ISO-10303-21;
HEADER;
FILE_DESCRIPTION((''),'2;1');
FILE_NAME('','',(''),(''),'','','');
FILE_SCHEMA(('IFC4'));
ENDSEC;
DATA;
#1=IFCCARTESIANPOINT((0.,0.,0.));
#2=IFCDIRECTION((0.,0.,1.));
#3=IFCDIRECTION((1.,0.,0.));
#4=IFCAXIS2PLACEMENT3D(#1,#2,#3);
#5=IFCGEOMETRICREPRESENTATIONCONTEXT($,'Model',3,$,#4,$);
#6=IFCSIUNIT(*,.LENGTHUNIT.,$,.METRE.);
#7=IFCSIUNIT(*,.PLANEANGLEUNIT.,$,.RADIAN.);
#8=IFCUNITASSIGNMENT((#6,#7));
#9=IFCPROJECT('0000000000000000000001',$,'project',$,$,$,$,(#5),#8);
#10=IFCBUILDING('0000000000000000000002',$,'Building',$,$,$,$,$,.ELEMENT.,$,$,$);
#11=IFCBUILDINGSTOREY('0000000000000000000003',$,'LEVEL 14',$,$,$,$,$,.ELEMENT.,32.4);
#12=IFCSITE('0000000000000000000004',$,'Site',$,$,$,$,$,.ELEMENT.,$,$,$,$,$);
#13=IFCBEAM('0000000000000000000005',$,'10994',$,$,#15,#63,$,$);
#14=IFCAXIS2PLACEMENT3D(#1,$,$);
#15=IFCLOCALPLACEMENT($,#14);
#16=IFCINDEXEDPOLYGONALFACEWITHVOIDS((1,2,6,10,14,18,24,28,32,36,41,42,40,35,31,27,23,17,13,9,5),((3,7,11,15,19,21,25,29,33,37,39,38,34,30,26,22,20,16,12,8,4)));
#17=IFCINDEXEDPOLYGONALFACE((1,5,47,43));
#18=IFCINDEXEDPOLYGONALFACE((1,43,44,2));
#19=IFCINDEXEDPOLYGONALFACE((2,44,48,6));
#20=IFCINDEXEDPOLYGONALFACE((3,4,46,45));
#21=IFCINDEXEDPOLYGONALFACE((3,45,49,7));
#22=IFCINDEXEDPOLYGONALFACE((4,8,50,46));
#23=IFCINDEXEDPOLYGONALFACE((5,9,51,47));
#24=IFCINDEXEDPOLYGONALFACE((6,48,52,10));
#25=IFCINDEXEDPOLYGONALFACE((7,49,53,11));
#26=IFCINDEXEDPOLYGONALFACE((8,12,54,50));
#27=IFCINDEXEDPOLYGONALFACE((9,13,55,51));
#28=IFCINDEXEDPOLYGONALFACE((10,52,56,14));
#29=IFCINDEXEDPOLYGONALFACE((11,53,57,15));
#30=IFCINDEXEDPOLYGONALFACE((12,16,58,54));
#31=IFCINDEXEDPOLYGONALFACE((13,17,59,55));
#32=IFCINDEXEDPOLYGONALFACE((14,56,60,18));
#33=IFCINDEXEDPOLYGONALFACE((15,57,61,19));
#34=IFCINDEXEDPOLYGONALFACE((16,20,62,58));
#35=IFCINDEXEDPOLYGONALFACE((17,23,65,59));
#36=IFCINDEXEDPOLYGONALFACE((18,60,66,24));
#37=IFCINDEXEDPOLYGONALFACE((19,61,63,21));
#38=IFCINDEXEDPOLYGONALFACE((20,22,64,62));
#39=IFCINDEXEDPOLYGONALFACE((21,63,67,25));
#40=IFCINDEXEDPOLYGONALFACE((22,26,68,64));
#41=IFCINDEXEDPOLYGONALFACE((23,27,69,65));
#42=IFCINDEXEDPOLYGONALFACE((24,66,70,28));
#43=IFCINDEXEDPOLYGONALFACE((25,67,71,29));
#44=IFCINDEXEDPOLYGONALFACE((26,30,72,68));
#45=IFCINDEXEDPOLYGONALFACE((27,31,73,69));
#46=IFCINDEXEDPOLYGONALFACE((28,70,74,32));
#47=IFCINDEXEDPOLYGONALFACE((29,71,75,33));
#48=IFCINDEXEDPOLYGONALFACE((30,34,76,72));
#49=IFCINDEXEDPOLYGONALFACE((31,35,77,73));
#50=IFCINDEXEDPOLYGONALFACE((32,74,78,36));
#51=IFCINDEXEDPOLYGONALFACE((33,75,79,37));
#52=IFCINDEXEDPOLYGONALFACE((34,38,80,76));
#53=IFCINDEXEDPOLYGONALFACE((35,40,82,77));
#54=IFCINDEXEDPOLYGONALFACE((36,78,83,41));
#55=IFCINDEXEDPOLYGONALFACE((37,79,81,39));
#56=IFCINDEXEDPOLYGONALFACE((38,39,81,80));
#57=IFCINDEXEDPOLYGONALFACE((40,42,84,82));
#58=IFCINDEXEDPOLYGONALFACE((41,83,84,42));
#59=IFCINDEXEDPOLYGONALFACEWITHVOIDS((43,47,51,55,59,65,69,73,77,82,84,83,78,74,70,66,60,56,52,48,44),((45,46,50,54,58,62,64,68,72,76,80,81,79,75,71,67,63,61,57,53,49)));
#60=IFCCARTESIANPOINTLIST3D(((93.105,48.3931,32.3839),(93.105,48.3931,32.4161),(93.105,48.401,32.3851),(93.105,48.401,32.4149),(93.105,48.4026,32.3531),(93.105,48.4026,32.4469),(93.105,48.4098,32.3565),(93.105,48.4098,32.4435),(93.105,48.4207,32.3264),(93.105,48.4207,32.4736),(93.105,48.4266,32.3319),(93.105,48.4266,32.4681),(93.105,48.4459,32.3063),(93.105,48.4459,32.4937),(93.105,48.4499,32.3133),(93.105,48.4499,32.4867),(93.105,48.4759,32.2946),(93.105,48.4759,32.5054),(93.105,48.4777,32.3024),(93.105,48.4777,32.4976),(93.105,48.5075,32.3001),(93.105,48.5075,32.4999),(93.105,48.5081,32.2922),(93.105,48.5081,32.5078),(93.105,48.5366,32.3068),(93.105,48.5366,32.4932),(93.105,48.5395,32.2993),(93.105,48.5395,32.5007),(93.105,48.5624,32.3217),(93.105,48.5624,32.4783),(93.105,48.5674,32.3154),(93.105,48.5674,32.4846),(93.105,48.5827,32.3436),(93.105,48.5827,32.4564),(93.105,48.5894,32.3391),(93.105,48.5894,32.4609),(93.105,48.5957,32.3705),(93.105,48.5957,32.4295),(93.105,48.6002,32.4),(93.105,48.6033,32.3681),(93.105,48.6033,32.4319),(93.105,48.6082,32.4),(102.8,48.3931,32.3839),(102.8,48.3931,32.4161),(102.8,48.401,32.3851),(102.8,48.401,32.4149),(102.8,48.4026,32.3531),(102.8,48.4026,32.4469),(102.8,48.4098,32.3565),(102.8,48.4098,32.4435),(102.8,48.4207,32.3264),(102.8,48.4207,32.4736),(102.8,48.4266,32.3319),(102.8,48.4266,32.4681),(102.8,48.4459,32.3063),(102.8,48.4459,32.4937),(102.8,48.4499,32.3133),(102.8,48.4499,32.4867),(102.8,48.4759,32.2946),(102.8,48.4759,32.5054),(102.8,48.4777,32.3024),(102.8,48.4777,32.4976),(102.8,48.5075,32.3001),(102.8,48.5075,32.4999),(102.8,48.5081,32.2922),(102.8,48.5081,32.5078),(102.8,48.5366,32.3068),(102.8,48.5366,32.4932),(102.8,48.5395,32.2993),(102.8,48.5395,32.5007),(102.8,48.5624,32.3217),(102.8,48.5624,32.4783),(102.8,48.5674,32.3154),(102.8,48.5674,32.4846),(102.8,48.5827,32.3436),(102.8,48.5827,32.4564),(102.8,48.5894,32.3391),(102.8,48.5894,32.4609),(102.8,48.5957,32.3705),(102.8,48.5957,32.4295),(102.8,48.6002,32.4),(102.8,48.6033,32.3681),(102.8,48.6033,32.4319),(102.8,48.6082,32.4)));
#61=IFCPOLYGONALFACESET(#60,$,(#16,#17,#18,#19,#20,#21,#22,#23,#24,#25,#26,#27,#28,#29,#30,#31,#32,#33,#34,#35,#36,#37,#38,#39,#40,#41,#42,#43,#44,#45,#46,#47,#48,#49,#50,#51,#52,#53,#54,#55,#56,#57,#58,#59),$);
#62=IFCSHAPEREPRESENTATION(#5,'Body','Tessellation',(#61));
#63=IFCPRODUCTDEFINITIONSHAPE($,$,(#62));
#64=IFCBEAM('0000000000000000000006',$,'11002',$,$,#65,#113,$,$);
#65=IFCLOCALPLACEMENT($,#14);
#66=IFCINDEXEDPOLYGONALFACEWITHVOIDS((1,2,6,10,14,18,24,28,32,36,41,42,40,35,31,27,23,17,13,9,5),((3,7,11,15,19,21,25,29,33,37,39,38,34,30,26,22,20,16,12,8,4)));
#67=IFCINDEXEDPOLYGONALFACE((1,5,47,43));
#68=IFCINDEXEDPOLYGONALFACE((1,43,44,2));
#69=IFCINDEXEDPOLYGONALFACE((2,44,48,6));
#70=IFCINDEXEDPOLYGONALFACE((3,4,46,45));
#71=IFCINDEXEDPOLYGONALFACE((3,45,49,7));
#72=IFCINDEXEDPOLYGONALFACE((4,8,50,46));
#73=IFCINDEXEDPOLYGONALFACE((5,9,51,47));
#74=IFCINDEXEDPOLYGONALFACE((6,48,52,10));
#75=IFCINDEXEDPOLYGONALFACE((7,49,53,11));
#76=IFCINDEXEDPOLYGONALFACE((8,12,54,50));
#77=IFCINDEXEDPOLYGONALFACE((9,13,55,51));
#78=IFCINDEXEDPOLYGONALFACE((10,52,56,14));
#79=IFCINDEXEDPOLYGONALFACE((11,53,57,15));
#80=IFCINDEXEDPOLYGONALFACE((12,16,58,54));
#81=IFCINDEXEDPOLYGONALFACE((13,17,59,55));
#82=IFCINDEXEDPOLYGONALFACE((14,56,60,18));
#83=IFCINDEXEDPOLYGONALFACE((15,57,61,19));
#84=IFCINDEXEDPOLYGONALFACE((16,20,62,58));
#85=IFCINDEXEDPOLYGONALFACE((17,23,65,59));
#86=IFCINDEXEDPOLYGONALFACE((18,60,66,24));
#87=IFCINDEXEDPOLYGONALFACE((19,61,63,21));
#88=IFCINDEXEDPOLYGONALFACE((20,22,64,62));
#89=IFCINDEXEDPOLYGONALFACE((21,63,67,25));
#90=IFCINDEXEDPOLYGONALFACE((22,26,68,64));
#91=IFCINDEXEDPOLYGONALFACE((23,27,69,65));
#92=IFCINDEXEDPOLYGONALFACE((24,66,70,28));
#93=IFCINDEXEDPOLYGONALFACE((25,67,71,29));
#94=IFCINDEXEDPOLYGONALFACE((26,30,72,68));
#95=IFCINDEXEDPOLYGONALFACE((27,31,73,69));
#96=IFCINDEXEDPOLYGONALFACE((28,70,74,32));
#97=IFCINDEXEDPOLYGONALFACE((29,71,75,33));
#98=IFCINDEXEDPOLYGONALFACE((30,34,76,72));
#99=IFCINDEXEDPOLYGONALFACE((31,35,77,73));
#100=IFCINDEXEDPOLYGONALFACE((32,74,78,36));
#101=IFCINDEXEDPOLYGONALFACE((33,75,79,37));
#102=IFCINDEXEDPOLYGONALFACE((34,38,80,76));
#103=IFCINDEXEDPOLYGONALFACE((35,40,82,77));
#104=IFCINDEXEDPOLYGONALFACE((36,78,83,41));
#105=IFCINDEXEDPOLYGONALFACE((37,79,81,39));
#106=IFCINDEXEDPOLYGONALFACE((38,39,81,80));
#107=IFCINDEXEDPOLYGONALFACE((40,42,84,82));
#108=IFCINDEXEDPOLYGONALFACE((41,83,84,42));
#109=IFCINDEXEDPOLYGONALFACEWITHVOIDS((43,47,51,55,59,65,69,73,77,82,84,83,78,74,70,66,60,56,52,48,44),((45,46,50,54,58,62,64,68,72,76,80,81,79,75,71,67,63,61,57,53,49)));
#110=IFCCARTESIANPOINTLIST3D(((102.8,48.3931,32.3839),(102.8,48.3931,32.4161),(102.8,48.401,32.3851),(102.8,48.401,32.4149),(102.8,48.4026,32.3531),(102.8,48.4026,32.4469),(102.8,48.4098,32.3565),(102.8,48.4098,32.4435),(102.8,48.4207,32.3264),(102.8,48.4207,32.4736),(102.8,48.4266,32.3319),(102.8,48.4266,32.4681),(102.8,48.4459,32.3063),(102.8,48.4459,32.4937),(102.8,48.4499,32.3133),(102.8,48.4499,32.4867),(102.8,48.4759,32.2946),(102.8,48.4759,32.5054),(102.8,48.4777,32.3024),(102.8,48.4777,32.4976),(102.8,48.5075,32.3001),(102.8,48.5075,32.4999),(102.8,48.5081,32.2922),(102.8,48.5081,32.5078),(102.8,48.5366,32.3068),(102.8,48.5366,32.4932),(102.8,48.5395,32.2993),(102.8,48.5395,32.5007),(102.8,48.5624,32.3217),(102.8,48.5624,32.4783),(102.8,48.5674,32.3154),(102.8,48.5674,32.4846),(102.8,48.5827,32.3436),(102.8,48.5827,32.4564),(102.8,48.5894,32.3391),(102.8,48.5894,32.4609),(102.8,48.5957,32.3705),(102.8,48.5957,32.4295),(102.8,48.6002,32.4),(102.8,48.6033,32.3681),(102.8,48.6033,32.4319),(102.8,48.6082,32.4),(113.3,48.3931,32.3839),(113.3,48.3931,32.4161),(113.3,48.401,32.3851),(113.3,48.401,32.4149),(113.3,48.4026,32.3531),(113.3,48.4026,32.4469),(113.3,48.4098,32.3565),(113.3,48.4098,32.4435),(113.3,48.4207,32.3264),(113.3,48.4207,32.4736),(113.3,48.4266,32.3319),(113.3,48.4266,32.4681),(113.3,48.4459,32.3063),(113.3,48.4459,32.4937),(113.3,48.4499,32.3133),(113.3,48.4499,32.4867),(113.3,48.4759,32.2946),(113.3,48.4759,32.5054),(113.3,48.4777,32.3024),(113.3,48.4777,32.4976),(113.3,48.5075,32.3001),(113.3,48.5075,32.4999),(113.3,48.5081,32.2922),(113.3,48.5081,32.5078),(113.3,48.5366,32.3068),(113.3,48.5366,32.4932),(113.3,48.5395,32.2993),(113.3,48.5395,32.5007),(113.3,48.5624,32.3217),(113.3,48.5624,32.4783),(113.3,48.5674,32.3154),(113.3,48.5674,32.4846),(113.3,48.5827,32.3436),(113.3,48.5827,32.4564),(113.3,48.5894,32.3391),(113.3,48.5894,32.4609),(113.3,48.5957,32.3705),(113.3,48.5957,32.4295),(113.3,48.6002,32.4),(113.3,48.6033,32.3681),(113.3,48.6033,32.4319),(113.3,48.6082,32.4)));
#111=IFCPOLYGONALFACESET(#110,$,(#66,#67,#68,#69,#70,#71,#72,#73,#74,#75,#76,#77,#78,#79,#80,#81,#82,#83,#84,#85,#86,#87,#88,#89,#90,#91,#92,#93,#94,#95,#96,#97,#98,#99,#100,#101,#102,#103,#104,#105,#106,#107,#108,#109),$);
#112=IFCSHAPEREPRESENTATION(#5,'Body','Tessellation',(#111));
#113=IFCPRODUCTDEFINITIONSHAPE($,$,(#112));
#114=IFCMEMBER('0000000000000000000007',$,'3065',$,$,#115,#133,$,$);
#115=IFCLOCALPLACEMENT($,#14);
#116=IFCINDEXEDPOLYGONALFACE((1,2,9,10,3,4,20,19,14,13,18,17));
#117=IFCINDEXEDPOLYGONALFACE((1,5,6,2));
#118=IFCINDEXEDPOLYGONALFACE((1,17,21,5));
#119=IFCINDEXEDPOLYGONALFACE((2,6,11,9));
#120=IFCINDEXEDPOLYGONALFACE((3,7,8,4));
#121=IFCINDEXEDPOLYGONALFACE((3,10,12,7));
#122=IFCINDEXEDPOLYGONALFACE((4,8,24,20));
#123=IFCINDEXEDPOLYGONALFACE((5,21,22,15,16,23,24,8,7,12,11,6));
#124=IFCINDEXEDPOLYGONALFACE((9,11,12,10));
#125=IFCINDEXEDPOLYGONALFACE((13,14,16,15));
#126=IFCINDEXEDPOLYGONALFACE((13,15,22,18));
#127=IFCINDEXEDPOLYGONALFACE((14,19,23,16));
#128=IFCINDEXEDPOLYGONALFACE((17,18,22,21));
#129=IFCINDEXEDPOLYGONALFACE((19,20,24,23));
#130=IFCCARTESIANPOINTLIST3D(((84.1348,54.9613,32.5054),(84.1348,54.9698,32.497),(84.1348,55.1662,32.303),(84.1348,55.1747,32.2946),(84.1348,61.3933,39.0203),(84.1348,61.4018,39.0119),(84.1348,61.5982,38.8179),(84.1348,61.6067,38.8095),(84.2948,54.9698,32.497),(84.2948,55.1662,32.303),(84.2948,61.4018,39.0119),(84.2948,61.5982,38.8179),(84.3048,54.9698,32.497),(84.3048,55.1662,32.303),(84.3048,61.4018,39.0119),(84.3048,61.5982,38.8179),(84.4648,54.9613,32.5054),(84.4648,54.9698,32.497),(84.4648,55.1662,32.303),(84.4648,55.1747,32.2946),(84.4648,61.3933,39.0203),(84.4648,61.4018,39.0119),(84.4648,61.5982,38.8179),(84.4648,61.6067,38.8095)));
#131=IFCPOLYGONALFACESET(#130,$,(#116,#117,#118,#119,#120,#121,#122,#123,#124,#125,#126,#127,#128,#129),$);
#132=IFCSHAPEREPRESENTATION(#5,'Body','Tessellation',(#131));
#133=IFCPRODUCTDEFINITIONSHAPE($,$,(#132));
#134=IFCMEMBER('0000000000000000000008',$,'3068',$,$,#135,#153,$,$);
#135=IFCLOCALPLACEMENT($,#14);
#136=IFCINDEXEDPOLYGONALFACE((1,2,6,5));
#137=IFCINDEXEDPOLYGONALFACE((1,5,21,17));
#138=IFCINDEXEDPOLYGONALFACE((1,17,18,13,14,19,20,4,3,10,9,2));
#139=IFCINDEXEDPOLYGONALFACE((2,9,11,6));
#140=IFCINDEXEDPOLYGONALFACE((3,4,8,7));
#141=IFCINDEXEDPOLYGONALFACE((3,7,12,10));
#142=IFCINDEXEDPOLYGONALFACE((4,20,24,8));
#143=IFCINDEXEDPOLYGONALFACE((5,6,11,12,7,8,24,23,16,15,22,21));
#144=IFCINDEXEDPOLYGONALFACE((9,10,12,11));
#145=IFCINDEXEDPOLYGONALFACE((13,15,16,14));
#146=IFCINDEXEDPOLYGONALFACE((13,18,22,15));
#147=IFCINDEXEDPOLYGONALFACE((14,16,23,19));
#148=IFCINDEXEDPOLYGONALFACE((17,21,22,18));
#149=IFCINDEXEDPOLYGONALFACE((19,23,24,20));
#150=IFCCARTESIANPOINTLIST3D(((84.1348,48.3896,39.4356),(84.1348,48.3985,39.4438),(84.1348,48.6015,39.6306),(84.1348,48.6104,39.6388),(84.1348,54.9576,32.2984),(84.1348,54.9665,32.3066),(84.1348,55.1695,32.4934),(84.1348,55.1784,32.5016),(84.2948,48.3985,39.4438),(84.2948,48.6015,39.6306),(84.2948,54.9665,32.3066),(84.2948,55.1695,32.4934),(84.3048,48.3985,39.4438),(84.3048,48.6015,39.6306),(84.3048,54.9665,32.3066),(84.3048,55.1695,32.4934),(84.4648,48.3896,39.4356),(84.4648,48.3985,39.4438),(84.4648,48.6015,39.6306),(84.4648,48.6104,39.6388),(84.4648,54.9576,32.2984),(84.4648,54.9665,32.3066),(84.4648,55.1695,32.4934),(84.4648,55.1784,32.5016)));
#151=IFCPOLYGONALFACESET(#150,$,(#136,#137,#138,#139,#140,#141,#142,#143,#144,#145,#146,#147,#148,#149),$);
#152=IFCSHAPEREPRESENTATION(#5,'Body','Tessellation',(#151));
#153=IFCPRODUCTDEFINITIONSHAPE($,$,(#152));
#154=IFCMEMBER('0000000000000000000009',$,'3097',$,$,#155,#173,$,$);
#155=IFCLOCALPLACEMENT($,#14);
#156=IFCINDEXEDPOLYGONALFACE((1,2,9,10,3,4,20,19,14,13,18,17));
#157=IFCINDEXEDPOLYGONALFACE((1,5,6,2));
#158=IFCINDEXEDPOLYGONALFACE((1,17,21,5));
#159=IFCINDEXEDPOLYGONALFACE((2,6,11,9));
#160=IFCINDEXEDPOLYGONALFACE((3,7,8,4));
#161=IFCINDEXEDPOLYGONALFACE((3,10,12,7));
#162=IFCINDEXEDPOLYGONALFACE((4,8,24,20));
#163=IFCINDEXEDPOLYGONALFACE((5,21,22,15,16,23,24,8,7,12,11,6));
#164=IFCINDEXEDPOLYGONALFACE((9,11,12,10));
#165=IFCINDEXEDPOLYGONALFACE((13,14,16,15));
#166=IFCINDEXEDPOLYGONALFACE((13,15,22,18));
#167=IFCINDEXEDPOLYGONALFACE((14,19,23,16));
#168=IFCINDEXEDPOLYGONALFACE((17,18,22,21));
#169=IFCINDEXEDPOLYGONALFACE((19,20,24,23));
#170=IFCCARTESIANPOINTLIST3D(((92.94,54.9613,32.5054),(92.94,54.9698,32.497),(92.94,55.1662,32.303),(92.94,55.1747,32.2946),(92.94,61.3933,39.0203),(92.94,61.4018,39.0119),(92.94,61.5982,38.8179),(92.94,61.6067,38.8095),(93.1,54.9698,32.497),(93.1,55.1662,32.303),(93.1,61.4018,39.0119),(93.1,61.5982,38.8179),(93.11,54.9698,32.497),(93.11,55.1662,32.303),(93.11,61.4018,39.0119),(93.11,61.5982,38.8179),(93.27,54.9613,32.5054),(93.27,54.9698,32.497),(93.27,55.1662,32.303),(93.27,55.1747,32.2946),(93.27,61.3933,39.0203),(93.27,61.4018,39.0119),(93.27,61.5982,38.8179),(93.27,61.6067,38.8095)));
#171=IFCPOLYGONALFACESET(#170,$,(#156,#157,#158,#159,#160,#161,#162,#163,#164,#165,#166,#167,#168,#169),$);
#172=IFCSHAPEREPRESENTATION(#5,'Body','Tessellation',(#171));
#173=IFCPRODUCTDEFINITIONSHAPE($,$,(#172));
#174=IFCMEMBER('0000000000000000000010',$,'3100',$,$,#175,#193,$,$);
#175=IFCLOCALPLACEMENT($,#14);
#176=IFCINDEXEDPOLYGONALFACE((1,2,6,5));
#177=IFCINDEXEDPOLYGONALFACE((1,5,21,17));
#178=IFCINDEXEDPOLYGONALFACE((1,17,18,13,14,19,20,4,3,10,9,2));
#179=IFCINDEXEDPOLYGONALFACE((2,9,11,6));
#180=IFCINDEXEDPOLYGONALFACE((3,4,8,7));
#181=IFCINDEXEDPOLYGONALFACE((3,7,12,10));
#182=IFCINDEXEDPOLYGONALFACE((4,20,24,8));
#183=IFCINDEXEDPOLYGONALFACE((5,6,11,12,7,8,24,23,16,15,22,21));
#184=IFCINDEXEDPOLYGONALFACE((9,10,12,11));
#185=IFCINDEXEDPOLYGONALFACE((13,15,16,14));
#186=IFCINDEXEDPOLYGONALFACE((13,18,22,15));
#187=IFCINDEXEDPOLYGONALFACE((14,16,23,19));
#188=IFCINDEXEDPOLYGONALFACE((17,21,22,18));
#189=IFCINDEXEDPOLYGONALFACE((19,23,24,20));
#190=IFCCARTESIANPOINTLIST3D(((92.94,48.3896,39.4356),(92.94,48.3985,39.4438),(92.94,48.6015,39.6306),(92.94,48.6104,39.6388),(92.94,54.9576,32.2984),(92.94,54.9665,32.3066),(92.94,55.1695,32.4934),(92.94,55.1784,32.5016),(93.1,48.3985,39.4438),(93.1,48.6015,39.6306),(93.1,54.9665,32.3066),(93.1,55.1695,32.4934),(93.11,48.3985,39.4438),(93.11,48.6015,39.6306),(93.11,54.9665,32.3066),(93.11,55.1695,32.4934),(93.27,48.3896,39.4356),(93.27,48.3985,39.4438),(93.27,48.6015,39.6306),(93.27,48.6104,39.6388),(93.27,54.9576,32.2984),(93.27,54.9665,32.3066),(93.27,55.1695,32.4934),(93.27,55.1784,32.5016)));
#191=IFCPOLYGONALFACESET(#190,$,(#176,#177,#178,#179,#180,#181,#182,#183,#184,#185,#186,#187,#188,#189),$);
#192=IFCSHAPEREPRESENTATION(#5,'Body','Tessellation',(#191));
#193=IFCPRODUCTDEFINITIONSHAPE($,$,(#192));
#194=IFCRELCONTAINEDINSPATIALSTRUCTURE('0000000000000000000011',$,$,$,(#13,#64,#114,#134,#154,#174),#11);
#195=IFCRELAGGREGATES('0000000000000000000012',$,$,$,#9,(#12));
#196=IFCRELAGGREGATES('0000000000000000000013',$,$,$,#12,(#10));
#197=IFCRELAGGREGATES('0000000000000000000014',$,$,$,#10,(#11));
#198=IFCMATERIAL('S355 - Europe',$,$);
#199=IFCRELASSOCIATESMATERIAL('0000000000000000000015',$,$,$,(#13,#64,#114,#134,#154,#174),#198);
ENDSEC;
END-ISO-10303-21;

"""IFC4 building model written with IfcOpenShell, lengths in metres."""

from ifc_helpers import new_model, si_unit, frame, origin_with_axes, origin_2d_with_axis, place, context, project, spatial, hollow_circle, i_section, extrude, material, material_profile, profile_set, profile_usage, element, save


model = new_model("IFC4")

# Units and contexts
model_context = context("Model", 3, world=origin_with_axes())
ifc_project = project(units=[si_unit("LENGTHUNIT", "METRE"), si_unit("PLANEANGLEUNIT", "RADIAN")], contexts=[model_context])

# Site, building, storey
site = spatial("IfcSite", under=ifc_project, Name="Site", CompositionType="ELEMENT")
building = spatial("IfcBuilding", under=site, Name="Building", CompositionType="ELEMENT")
storey = spatial("IfcBuildingStorey", under=building, Name="LEVEL 14", CompositionType="ELEMENT", Elevation=32.4)

# Shared definitions
ifc_material = material(Name="S355 - Europe")

# Beams
ifc_material_profile_1 = material_profile(ifc_material, hollow_circle(Radius=0.1081, WallThickness=0.008, at=origin_2d_with_axis()))
ifc_profile_set_1 = profile_set([ifc_material_profile_1])
ifc_profile_usage_1 = profile_usage(ifc_profile_set_1, cardinal=10)
beam_1_placement = place(None, frame((93.105, 48.5, 32.4), z_axis=(1.0, 0.0, 0.0), x_axis=(0.0, 1.0, 0.0)))
element("IfcBeam", 1, at=beam_1_placement, inside=storey, material=ifc_profile_usage_1, Name="10994", context=model_context, shape_type="SweptSolid", body=[
    extrude(hollow_circle(Radius=0.1081, WallThickness=0.008, at=origin_2d_with_axis()), origin_with_axes(), (0.0, 0.0, 1.0), 9.695),
])
ifc_material_profile_2 = material_profile(ifc_material, hollow_circle(Radius=0.1081, WallThickness=0.008, at=origin_2d_with_axis()))
ifc_profile_set_2 = profile_set([ifc_material_profile_2])
ifc_profile_usage_2 = profile_usage(ifc_profile_set_2, cardinal=10)
beam_2_placement = place(None, frame((102.8, 48.5, 32.4), z_axis=(1.0, 0.0, 0.0), x_axis=(0.0, 1.0, 0.0)))
element("IfcBeam", 2, at=beam_2_placement, inside=storey, material=ifc_profile_usage_2, Name="11002", context=model_context, shape_type="SweptSolid", body=[
    extrude(hollow_circle(Radius=0.1081, WallThickness=0.008, at=origin_2d_with_axis()), origin_with_axes(), (0.0, 0.0, 1.0), 10.5),
])

# Members
ifc_material_profile_3 = material_profile(ifc_material, i_section(OverallWidth=0.33, OverallDepth=0.3, WebThickness=0.01, FlangeThickness=0.012, at=origin_2d_with_axis()))
ifc_profile_set_3 = profile_set([ifc_material_profile_3])
ifc_profile_usage_3 = profile_usage(ifc_profile_set_3, cardinal=10)
member_1_placement = place(None, frame((84.2998, 55.068, 32.4), z_axis=(0.0, 0.702565, 0.71162), x_axis=(-1.0, 0.0, 0.0)))
element("IfcMember", 3, at=member_1_placement, inside=storey, material=ifc_profile_usage_3, Name="3065", context=model_context, shape_type="SweptSolid", body=[
    extrude(i_section(OverallWidth=0.33, OverallDepth=0.3, WebThickness=0.01, FlangeThickness=0.012, at=origin_2d_with_axis()), origin_with_axes(), (0.0, 0.0, 1.0), 9.155),
])
ifc_material_profile_4 = material_profile(ifc_material, i_section(OverallWidth=0.33, OverallDepth=0.3, WebThickness=0.01, FlangeThickness=0.012, at=origin_2d_with_axis()))
ifc_profile_set_4 = profile_set([ifc_material_profile_4])
ifc_profile_usage_4 = profile_usage(ifc_profile_set_4, cardinal=10)
member_2_placement = place(None, frame((84.2998, 48.5, 39.5372), z_axis=(0.0, 0.677156, -0.73584), x_axis=(-1.0, 0.0, 0.0)))
element("IfcMember", 4, at=member_2_placement, inside=storey, material=ifc_profile_usage_4, Name="3068", context=model_context, shape_type="SweptSolid", body=[
    extrude(i_section(OverallWidth=0.33, OverallDepth=0.3, WebThickness=0.01, FlangeThickness=0.012, at=origin_2d_with_axis()), origin_with_axes(), (0.0, 0.0, 1.0), 9.6994),
])
ifc_material_profile_5 = material_profile(ifc_material, i_section(OverallWidth=0.33, OverallDepth=0.3, WebThickness=0.01, FlangeThickness=0.012, at=origin_2d_with_axis()))
ifc_profile_set_5 = profile_set([ifc_material_profile_5])
ifc_profile_usage_5 = profile_usage(ifc_profile_set_5, cardinal=10)
member_3_placement = place(None, frame((93.105, 55.068, 32.4), z_axis=(0.0, 0.702565, 0.71162), x_axis=(-1.0, 0.0, 0.0)))
element("IfcMember", 5, at=member_3_placement, inside=storey, material=ifc_profile_usage_5, Name="3097", context=model_context, shape_type="SweptSolid", body=[
    extrude(i_section(OverallWidth=0.33, OverallDepth=0.3, WebThickness=0.01, FlangeThickness=0.012, at=origin_2d_with_axis()), origin_with_axes(), (0.0, 0.0, 1.0), 9.155),
])
ifc_material_profile_6 = material_profile(ifc_material, i_section(OverallWidth=0.33, OverallDepth=0.3, WebThickness=0.01, FlangeThickness=0.012, at=origin_2d_with_axis()))
ifc_profile_set_6 = profile_set([ifc_material_profile_6])
ifc_profile_usage_6 = profile_usage(ifc_profile_set_6, cardinal=10)
member_4_placement = place(None, frame((93.105, 55.068, 32.4), z_axis=(0.0, -0.677156, 0.73584), x_axis=(1.0, 0.0, 0.0)))
element("IfcMember", 6, at=member_4_placement, inside=storey, material=ifc_profile_usage_6, Name="3100", context=model_context, shape_type="SweptSolid", body=[
    extrude(i_section(OverallWidth=0.33, OverallDepth=0.3, WebThickness=0.01, FlangeThickness=0.012, at=origin_2d_with_axis()), origin_with_axes(), (0.0, 0.0, 1.0), 9.6994),
])

save(model, "model.ifc")
